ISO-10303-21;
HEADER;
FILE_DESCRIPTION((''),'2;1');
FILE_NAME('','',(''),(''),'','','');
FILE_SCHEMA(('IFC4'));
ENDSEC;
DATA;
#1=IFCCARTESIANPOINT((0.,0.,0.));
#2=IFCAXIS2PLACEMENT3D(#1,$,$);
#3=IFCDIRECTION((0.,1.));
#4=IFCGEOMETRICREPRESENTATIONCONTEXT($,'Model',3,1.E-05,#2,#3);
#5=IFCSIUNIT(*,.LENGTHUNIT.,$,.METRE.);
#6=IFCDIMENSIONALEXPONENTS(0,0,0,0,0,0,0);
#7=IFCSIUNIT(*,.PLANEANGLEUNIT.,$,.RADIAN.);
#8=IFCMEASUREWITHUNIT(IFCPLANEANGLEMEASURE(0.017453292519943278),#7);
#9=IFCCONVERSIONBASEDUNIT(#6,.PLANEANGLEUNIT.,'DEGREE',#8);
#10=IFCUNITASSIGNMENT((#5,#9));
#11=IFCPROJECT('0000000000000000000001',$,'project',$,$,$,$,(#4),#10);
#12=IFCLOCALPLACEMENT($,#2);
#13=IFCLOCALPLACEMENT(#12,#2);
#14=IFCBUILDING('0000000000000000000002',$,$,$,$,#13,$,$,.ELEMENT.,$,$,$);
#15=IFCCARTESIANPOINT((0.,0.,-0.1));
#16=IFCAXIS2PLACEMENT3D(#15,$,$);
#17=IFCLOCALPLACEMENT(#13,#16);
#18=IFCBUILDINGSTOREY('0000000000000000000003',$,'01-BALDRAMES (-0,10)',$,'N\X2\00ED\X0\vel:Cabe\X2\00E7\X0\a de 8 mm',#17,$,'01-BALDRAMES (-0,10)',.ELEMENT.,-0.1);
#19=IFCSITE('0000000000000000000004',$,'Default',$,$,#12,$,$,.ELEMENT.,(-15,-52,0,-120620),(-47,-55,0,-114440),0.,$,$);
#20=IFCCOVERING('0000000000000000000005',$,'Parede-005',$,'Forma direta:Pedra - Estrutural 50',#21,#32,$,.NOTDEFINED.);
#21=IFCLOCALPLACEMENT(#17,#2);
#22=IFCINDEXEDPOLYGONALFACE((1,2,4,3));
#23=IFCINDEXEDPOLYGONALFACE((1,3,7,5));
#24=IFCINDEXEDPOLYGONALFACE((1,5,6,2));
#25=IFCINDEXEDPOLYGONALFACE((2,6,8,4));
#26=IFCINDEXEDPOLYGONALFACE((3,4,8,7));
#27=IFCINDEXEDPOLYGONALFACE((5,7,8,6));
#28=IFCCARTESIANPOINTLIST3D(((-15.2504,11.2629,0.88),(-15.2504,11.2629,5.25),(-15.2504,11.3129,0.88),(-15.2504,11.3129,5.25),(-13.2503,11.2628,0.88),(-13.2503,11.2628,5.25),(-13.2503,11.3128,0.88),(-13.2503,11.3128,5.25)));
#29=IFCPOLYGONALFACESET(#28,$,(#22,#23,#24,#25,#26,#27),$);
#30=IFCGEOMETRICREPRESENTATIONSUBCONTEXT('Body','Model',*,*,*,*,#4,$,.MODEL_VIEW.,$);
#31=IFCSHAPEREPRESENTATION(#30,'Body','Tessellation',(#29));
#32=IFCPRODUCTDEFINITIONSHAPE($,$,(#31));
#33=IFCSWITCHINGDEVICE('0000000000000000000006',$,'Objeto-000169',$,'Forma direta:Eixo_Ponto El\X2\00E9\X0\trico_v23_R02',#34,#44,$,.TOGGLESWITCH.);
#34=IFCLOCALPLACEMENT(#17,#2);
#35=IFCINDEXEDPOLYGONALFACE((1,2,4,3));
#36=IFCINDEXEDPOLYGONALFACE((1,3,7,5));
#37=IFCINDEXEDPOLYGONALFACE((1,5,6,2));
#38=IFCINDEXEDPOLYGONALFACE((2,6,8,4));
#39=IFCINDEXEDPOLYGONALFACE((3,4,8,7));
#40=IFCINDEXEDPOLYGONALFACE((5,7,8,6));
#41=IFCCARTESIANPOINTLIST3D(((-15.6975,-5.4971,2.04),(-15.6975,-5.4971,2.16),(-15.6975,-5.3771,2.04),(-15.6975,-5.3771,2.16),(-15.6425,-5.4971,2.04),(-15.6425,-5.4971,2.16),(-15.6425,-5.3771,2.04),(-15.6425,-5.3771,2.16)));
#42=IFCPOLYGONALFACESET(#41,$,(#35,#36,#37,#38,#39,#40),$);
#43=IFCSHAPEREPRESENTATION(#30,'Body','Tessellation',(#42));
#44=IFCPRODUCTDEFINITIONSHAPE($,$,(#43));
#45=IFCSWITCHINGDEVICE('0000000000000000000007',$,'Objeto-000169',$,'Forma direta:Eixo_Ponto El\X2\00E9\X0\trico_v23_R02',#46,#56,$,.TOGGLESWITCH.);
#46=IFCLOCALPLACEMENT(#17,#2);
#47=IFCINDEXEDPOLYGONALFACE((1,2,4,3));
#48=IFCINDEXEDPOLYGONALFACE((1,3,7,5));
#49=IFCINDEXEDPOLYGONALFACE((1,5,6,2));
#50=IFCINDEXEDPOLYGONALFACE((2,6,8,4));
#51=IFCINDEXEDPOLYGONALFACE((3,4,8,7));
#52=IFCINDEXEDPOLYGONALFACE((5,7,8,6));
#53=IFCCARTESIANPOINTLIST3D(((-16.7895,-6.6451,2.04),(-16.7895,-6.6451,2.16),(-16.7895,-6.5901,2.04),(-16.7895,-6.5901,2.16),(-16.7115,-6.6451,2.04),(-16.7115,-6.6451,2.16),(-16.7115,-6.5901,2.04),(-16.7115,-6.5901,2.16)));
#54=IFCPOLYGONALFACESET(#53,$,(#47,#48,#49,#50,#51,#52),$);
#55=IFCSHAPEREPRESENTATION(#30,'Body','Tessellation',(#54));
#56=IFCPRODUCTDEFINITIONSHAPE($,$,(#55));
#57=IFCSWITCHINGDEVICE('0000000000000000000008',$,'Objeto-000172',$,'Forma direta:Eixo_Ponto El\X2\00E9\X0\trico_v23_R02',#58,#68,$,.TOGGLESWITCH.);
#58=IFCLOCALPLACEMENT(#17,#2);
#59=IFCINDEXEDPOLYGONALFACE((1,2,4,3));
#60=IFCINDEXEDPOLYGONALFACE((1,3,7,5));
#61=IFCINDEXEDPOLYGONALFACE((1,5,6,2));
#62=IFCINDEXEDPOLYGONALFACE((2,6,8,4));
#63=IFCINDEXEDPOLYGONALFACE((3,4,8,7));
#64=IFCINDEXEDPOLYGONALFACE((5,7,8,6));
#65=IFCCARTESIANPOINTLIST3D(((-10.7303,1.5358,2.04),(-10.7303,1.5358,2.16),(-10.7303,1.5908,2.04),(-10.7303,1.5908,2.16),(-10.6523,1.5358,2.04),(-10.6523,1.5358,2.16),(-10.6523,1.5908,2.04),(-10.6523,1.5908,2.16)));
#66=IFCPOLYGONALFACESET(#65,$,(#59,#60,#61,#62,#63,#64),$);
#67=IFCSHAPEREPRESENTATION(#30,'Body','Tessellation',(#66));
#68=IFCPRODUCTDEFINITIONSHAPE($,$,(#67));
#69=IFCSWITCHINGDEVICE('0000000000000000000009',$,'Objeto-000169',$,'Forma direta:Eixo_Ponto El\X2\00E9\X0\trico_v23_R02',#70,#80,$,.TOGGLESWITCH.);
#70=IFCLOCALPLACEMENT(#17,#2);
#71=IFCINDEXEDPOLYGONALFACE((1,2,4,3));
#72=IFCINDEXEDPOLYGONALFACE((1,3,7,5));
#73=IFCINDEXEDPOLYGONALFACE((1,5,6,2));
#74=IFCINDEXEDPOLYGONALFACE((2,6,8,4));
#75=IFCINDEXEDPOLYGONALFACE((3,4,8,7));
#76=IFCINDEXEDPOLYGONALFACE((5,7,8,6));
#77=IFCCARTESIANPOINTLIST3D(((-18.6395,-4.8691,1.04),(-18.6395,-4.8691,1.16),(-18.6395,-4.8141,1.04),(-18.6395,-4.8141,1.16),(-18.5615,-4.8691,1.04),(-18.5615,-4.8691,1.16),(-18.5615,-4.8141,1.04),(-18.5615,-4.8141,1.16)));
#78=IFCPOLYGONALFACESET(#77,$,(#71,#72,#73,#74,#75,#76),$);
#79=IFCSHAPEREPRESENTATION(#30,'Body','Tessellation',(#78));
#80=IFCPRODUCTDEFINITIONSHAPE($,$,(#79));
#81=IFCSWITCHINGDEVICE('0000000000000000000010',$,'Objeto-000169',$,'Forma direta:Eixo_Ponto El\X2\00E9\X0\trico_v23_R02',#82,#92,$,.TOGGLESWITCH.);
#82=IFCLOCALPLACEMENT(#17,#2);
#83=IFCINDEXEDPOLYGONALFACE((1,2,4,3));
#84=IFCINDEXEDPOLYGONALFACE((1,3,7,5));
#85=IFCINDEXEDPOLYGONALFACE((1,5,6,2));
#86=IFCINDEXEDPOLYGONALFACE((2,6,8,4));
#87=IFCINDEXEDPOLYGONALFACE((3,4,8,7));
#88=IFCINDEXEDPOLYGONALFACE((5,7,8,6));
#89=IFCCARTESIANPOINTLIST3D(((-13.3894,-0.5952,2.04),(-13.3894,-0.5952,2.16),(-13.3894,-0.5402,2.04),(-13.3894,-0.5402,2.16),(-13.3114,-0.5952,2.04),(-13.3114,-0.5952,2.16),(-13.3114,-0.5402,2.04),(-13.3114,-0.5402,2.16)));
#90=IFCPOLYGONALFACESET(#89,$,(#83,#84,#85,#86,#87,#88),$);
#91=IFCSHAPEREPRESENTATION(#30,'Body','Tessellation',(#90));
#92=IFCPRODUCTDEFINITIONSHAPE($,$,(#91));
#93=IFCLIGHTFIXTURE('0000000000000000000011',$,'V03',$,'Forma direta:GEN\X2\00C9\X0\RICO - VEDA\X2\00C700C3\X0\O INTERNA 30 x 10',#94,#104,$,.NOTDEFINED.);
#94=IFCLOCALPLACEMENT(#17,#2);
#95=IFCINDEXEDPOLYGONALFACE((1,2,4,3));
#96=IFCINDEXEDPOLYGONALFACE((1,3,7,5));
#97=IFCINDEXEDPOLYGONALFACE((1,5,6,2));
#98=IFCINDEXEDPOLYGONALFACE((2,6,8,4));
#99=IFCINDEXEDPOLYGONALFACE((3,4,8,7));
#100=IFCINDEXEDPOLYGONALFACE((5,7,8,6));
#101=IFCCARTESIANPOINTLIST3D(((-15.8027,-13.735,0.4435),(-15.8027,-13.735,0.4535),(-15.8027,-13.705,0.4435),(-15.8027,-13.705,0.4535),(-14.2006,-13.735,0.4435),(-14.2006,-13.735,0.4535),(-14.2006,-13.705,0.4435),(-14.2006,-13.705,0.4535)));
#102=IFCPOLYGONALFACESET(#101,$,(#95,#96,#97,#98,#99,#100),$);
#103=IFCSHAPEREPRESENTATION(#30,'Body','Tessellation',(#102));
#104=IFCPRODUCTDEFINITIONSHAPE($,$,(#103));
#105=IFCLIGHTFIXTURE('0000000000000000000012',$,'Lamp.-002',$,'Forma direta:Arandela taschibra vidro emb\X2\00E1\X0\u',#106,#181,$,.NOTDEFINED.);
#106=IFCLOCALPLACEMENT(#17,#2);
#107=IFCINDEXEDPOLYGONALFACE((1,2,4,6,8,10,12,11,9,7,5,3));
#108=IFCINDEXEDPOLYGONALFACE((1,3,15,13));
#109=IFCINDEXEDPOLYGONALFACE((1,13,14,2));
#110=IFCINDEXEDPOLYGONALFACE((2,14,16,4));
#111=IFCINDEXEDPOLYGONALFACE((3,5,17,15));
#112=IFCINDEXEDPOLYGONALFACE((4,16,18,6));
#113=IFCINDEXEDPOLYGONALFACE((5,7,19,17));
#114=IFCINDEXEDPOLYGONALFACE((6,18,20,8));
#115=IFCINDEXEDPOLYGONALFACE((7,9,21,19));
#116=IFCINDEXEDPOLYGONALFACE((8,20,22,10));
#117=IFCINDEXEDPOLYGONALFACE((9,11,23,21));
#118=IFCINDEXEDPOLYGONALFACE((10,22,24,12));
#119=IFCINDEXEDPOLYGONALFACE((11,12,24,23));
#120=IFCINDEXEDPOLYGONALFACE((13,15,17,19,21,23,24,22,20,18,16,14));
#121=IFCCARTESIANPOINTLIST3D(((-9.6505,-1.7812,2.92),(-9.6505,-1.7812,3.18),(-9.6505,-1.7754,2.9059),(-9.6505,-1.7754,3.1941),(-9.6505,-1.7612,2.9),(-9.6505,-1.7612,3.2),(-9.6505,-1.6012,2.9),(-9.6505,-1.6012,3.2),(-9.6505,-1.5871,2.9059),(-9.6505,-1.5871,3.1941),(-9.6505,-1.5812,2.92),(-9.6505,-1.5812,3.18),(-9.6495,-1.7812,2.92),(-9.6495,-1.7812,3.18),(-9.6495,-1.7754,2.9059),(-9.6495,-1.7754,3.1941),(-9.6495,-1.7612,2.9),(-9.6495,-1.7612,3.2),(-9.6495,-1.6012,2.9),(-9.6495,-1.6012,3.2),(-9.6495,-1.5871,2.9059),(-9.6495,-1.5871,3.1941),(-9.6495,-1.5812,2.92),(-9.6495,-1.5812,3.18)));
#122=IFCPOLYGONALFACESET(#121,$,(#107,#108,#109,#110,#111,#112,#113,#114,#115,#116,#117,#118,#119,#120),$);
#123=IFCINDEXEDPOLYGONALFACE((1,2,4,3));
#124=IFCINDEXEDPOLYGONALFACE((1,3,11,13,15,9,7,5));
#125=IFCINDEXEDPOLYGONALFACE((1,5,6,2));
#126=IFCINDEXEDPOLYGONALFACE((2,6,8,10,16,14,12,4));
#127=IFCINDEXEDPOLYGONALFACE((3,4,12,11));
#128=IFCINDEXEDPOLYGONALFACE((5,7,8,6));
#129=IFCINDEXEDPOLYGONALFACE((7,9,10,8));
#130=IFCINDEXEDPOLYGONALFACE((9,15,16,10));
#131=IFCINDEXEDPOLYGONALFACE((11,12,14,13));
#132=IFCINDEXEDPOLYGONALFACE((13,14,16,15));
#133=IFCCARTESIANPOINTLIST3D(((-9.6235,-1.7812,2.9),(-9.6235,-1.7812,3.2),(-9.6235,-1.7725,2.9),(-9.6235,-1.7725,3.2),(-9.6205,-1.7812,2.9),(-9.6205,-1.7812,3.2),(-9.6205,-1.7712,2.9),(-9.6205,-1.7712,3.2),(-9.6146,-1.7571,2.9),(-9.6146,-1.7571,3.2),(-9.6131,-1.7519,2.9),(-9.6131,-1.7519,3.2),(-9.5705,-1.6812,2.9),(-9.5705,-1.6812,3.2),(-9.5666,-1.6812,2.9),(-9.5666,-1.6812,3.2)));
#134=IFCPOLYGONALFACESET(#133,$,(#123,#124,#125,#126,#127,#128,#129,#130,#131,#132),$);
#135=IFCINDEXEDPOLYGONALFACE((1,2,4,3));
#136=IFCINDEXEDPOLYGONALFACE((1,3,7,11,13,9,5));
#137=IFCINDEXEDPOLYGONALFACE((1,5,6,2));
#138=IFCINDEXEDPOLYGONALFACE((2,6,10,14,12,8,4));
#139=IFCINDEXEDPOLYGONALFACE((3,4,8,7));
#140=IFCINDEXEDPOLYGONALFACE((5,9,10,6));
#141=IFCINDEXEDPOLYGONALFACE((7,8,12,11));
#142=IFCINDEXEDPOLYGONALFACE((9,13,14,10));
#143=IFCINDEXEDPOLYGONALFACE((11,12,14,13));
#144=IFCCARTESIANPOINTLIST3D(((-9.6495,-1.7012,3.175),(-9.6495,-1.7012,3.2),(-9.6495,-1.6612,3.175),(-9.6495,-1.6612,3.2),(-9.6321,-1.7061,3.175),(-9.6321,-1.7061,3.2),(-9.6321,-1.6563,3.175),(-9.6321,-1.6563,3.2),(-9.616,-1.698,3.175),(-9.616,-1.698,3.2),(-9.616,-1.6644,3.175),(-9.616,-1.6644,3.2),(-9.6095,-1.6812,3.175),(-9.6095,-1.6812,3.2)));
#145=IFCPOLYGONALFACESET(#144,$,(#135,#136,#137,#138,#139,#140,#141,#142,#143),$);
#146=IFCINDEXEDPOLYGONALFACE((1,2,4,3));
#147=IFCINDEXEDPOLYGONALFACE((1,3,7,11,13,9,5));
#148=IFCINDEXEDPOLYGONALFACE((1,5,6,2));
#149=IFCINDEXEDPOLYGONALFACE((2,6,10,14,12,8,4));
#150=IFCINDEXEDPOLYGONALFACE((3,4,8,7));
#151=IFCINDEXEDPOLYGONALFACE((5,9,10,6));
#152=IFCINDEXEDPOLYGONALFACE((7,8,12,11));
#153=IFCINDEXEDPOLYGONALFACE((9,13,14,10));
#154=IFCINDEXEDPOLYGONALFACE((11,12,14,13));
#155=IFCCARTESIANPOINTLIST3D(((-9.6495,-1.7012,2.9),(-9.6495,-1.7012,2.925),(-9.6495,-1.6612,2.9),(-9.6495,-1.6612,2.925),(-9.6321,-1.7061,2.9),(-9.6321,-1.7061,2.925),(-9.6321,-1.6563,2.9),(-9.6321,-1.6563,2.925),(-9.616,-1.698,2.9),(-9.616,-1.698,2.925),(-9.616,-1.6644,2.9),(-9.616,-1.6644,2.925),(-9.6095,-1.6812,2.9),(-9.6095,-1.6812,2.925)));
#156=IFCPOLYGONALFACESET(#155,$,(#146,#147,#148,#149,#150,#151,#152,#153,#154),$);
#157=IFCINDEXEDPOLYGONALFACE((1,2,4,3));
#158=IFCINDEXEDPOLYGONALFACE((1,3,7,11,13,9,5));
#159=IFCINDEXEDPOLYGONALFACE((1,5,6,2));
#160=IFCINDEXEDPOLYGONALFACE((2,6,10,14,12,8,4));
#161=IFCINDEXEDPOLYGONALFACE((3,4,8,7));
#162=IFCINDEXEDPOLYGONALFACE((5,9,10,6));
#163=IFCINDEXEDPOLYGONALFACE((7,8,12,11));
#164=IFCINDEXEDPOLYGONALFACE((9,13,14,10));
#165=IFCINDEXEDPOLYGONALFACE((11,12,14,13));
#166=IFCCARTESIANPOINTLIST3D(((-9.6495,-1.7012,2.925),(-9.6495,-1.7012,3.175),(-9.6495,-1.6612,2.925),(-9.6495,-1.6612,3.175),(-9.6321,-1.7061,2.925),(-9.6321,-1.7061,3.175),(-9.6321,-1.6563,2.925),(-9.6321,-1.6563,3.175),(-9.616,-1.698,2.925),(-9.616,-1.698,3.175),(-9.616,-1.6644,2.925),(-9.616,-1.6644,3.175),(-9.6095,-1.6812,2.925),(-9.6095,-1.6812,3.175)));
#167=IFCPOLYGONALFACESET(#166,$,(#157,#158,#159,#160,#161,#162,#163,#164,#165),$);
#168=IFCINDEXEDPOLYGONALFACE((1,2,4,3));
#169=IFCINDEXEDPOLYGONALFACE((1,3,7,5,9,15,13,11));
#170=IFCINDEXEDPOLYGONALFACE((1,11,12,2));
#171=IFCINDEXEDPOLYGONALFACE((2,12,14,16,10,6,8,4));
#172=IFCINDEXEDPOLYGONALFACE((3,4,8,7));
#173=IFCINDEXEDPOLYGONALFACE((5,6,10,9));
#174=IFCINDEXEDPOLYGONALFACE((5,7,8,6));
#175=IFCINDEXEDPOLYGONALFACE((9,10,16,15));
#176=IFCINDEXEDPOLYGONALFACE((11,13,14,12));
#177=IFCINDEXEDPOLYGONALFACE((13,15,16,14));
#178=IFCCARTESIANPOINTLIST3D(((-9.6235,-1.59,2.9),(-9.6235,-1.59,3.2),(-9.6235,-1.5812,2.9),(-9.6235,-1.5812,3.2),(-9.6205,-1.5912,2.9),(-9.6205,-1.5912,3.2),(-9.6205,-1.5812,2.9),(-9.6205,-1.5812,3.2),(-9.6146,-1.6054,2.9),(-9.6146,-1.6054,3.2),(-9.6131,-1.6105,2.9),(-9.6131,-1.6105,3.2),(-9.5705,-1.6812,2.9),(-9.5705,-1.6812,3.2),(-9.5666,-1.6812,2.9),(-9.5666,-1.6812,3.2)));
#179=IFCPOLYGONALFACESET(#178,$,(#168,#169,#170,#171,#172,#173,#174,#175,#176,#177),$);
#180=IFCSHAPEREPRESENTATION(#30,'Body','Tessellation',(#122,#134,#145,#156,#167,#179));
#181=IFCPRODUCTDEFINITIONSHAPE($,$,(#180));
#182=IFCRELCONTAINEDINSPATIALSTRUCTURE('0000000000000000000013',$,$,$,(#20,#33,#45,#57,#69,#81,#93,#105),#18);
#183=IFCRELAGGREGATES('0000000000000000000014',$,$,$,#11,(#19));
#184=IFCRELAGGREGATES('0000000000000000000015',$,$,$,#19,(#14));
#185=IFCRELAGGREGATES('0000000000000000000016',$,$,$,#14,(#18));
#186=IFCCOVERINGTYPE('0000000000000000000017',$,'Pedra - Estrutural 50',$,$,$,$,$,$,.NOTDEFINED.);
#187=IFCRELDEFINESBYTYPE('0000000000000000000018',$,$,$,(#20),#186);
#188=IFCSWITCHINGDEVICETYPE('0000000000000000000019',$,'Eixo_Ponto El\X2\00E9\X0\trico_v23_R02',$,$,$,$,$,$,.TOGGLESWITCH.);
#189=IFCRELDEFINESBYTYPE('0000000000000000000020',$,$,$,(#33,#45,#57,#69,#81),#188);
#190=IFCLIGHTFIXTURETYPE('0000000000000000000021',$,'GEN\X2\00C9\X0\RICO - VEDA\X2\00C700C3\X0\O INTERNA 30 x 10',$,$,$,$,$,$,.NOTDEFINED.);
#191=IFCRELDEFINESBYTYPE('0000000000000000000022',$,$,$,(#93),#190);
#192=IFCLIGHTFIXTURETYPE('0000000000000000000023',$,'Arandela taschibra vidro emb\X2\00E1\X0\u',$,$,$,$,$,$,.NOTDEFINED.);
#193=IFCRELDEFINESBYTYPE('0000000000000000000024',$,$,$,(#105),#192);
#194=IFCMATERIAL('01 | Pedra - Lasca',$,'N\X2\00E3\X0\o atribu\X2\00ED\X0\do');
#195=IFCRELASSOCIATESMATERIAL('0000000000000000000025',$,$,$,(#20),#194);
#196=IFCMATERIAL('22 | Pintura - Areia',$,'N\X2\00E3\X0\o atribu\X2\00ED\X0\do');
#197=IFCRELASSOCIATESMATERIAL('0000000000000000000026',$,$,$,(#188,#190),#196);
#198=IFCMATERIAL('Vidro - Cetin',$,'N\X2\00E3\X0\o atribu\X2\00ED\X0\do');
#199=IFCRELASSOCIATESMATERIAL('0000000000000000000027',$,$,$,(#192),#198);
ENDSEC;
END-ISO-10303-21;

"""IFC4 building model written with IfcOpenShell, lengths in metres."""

from ifc_helpers import new_model, entity, si_unit, converted_unit, direction, frame, origin, place, context, subcontext, project, spatial, indexed_curve, outline, extrude, material, type_object, element, save


model = new_model("IFC4")

# Units and contexts
model_context = context("Model", 3, precision=1e-05, world=origin(), true_north=direction((0.0, 1.0)))
body_context = subcontext(model_context, "Body", "Model", "MODEL_VIEW")
ifc_project = project(units=[si_unit("LENGTHUNIT", "METRE"), converted_unit("PLANEANGLEUNIT", "DEGREE", entity("IfcPlaneAngleMeasure", 0.017453292519943278), si_unit("PLANEANGLEUNIT", "RADIAN"), dimensions=[0, 0, 0, 0, 0, 0, 0])], contexts=[model_context])

# Site, building, storey
site_placement = place(None, origin())
site = spatial("IfcSite", under=ifc_project, at=site_placement, Name="Default", CompositionType="ELEMENT", RefLatitude=(-15, -52, 0, -120620), RefLongitude=(-47, -55, 0, -114440), RefElevation=0.0)
building_placement = place(site_placement, origin())
building = spatial("IfcBuilding", under=site, at=building_placement, CompositionType="ELEMENT")
storey_placement = place(building_placement, frame((0.0, 0.0, -0.1)))
storey = spatial("IfcBuildingStorey", under=building, at=storey_placement, Name="01-BALDRAMES (-0,10)", ObjectType="Nível:Cabeça de 8 mm", LongName="01-BALDRAMES (-0,10)", CompositionType="ELEMENT", Elevation=-0.1)

# Covering
ifc_material_1 = material(Name="01 | Pedra - Lasca", Category="Não atribuído")
covering_type = type_object("IfcCoveringType", Name="Pedra - Estrutural 50", PredefinedType="NOTDEFINED")
covering_placement = place(storey_placement, origin())
element("IfcCovering", 1, at=covering_placement, inside=storey, type_object=covering_type, material=ifc_material_1, Name="Parede-005", ObjectType="Forma direta:Pedra - Estrutural 50", PredefinedType="NOTDEFINED", context=body_context, shape_type="SweptSolid", body=[
    extrude(outline(indexed_curve([(-0.025, -1.0), (0.025, -1.0), (0.025, 1.0), (-0.025, 1.0), (-0.025, -1.0)], self_intersect=False)), frame((-14.2503, 11.2878, 0.88), z_axis=(0.0, 0.0, 1.0), x_axis=(-0.000013, -1.0, 0.0)), (0.0, 0.0, 1.0), 4.37),
])

# Switching devices
ifc_material_2 = material(Name="22 | Pintura - Areia", Category="Não atribuído")
switching_device_type_1 = type_object("IfcSwitchingDeviceType", Name="Eixo_Ponto Elétrico_v23_R02", PredefinedType="TOGGLESWITCH", material=ifc_material_2)
switching_device_1_placement = place(storey_placement, origin())
element("IfcSwitchingDevice", 2, at=switching_device_1_placement, inside=storey, type_object=switching_device_type_1, Name="Objeto-000169", ObjectType="Forma direta:Eixo_Ponto Elétrico_v23_R02", PredefinedType="TOGGLESWITCH", context=body_context, shape_type="SweptSolid", body=[
    extrude(outline(indexed_curve([(-0.0275, -0.06), (0.0275, -0.06), (0.0275, 0.06), (-0.0275, 0.06), (-0.0275, -0.06)], self_intersect=False)), frame((-15.67, -5.4371, 2.04), z_axis=(0.0, 0.0, 1.0), x_axis=(-1.0, 0.000011, 0.0)), (0.0, 0.0, 1.0), 0.12),
])
switching_device_2_placement = place(storey_placement, origin())
element("IfcSwitchingDevice", 3, at=switching_device_2_placement, inside=storey, type_object=switching_device_type_1, Name="Objeto-000169", ObjectType="Forma direta:Eixo_Ponto Elétrico_v23_R02", PredefinedType="TOGGLESWITCH", context=body_context, shape_type="SweptSolid", body=[
    extrude(outline(indexed_curve([(-0.0275, -0.039), (0.0275, -0.039), (0.0275, 0.039), (-0.0275, 0.039), (-0.0275, -0.039)], self_intersect=False)), frame((-16.7505, -6.6176, 2.04), z_axis=(0.0, 0.0, 1.0), x_axis=(0.000008, 1.0, 0.0)), (0.0, 0.0, 1.0), 0.12),
])
switching_device_3_placement = place(storey_placement, origin())
element("IfcSwitchingDevice", 4, at=switching_device_3_placement, inside=storey, type_object=switching_device_type_1, Name="Objeto-000172", ObjectType="Forma direta:Eixo_Ponto Elétrico_v23_R02", PredefinedType="TOGGLESWITCH", context=body_context, shape_type="SweptSolid", body=[
    extrude(outline(indexed_curve([(-0.0275, -0.039), (0.0275, -0.039), (0.0275, 0.039), (-0.0275, 0.039), (-0.0275, -0.039)], self_intersect=False)), frame((-10.6913, 1.5633, 2.04), z_axis=(0.0, 0.0, 1.0), x_axis=(-0.000013, -1.0, 0.0)), (0.0, 0.0, 1.0), 0.12),
])
switching_device_4_placement = place(storey_placement, origin())
element("IfcSwitchingDevice", 5, at=switching_device_4_placement, inside=storey, type_object=switching_device_type_1, Name="Objeto-000169", ObjectType="Forma direta:Eixo_Ponto Elétrico_v23_R02", PredefinedType="TOGGLESWITCH", context=body_context, shape_type="SweptSolid", body=[
    extrude(outline(indexed_curve([(-0.0275, -0.039), (0.0275, -0.039), (0.0275, 0.039), (-0.0275, 0.039), (-0.0275, -0.039)], self_intersect=False)), frame((-18.6005, -4.8416, 1.04), z_axis=(0.0, 0.0, 1.0), x_axis=(-0.000013, -1.0, 0.0)), (0.0, 0.0, 1.0), 0.12),
])
switching_device_5_placement = place(storey_placement, origin())
element("IfcSwitchingDevice", 6, at=switching_device_5_placement, inside=storey, type_object=switching_device_type_1, Name="Objeto-000169", ObjectType="Forma direta:Eixo_Ponto Elétrico_v23_R02", PredefinedType="TOGGLESWITCH", context=body_context, shape_type="SweptSolid", body=[
    extrude(outline(indexed_curve([(-0.0275, -0.039), (0.0275, -0.039), (0.0275, 0.039), (-0.0275, 0.039), (-0.0275, -0.039)], self_intersect=False)), frame((-13.3504, -0.5677, 2.04), z_axis=(0.0, 0.0, 1.0), x_axis=(0.000013, 1.0, 0.0)), (0.0, 0.0, 1.0), 0.12),
])

# Light fixtures
light_fixture_type_1 = type_object("IfcLightFixtureType", Name="GENÉRICO - VEDAÇÃO INTERNA 30 x 10", PredefinedType="NOTDEFINED", material=ifc_material_2)
light_fixture_1_placement = place(storey_placement, origin())
element("IfcLightFixture", 7, at=light_fixture_1_placement, inside=storey, type_object=light_fixture_type_1, Name="V03", ObjectType="Forma direta:GENÉRICO - VEDAÇÃO INTERNA 30 x 10", PredefinedType="NOTDEFINED", context=body_context, shape_type="SweptSolid", body=[
    extrude(outline(indexed_curve([(-0.801, -0.015), (0.801, -0.015), (0.801, 0.015), (-0.801, 0.015), (-0.801, -0.015)], self_intersect=False)), frame((-15.0016, -13.72, 0.4435)), (0.0, 0.0, 1.0), 0.01),
])
ifc_material_3 = material(Name="Vidro - Cetin", Category="Não atribuído")
light_fixture_type_2 = type_object("IfcLightFixtureType", Name="Arandela taschibra vidro embáu", PredefinedType="NOTDEFINED", material=ifc_material_3)
light_fixture_2_placement = place(storey_placement, origin())
element("IfcLightFixture", 8, at=light_fixture_2_placement, inside=storey, type_object=light_fixture_type_2, Name="Lamp.-002", ObjectType="Forma direta:Arandela taschibra vidro embáu", PredefinedType="NOTDEFINED", context=body_context, shape_type="SweptSolid", body=[
    extrude(outline(indexed_curve([(0.0165, -0.1692), (0.0318, -0.1692), (0.0426, -0.1584), (0.1421, 0.0818), (0.1421, 0.0971), (0.1313, 0.108), (-0.0165, 0.1692), (-0.0318, 0.1692), (-0.0426, 0.1584), (-0.1421, -0.0818), (-0.1421, -0.0971), (-0.1313, -0.108), (0.0165, -0.1692)], self_intersect=False)), frame((-9.6505, -1.6812, 3.05), z_axis=(1.0, -0.000013, 0.0), x_axis=(0.000012, 0.92388, 0.382683)), (0.0, 0.0, 1.0), 0.001),
    extrude(outline(indexed_curve([(-0.0169, -0.034), (-0.0139, -0.034), (-0.0139, -0.024), (-0.008, -0.0099), (0.04, 0.066), (0.0361, 0.066), (-0.0065, -0.0047), (-0.0169, -0.0253), (-0.0169, -0.034)], self_intersect=False)), frame((-9.6066, -1.7472, 2.9)), (0.0, 0.0, 1.0), 0.3),
    extrude(outline(indexed_curve([(-0.0141, -0.0247), (0.004, -0.0247), (0.0173, -0.0126), (0.019, 0.0054), (0.0082, 0.0198), (-0.0095, 0.0232), (-0.0249, 0.0138), (-0.0141, -0.0247)], self_intersect=False)), frame((-9.6292, -1.6812, 3.175), z_axis=(0.0, 0.0, 1.0), x_axis=(0.96257, -0.271031, 0.0)), (0.0, 0.0, 1.0), 0.025),
    extrude(outline(indexed_curve([(-0.0141, -0.0247), (0.004, -0.0247), (0.0173, -0.0126), (0.019, 0.0054), (0.0082, 0.0198), (-0.0095, 0.0232), (-0.0249, 0.0138), (-0.0141, -0.0247)], self_intersect=False)), frame((-9.6292, -1.6812, 2.9), z_axis=(0.0, 0.0, 1.0), x_axis=(0.96257, -0.271031, 0.0)), (0.0, 0.0, 1.0), 0.025),
    extrude(outline(indexed_curve([(-0.0141, -0.0247), (0.004, -0.0247), (0.0173, -0.0126), (0.019, 0.0054), (0.0082, 0.0198), (-0.0095, 0.0232), (-0.0249, 0.0138), (-0.0141, -0.0247)], self_intersect=False)), frame((-9.6292, -1.6812, 2.925), z_axis=(0.0, 0.0, 1.0), x_axis=(0.96257, -0.271031, 0.0)), (0.0, 0.0, 1.0), 0.25),
    extrude(outline(indexed_curve([(-0.034, -0.0169), (-0.0253, -0.0169), (-0.0047, -0.0065), (0.066, 0.0361), (0.066, 0.04), (-0.0099, -0.008), (-0.024, -0.0139), (-0.034, -0.0139), (-0.034, -0.0169)], self_intersect=False)), frame((-9.6066, -1.6152, 2.9), z_axis=(0.0, 0.0, 1.0), x_axis=(0.000426, -1.0, 0.0)), (0.0, 0.0, 1.0), 0.3),
])

save(model, "model.ifc")
